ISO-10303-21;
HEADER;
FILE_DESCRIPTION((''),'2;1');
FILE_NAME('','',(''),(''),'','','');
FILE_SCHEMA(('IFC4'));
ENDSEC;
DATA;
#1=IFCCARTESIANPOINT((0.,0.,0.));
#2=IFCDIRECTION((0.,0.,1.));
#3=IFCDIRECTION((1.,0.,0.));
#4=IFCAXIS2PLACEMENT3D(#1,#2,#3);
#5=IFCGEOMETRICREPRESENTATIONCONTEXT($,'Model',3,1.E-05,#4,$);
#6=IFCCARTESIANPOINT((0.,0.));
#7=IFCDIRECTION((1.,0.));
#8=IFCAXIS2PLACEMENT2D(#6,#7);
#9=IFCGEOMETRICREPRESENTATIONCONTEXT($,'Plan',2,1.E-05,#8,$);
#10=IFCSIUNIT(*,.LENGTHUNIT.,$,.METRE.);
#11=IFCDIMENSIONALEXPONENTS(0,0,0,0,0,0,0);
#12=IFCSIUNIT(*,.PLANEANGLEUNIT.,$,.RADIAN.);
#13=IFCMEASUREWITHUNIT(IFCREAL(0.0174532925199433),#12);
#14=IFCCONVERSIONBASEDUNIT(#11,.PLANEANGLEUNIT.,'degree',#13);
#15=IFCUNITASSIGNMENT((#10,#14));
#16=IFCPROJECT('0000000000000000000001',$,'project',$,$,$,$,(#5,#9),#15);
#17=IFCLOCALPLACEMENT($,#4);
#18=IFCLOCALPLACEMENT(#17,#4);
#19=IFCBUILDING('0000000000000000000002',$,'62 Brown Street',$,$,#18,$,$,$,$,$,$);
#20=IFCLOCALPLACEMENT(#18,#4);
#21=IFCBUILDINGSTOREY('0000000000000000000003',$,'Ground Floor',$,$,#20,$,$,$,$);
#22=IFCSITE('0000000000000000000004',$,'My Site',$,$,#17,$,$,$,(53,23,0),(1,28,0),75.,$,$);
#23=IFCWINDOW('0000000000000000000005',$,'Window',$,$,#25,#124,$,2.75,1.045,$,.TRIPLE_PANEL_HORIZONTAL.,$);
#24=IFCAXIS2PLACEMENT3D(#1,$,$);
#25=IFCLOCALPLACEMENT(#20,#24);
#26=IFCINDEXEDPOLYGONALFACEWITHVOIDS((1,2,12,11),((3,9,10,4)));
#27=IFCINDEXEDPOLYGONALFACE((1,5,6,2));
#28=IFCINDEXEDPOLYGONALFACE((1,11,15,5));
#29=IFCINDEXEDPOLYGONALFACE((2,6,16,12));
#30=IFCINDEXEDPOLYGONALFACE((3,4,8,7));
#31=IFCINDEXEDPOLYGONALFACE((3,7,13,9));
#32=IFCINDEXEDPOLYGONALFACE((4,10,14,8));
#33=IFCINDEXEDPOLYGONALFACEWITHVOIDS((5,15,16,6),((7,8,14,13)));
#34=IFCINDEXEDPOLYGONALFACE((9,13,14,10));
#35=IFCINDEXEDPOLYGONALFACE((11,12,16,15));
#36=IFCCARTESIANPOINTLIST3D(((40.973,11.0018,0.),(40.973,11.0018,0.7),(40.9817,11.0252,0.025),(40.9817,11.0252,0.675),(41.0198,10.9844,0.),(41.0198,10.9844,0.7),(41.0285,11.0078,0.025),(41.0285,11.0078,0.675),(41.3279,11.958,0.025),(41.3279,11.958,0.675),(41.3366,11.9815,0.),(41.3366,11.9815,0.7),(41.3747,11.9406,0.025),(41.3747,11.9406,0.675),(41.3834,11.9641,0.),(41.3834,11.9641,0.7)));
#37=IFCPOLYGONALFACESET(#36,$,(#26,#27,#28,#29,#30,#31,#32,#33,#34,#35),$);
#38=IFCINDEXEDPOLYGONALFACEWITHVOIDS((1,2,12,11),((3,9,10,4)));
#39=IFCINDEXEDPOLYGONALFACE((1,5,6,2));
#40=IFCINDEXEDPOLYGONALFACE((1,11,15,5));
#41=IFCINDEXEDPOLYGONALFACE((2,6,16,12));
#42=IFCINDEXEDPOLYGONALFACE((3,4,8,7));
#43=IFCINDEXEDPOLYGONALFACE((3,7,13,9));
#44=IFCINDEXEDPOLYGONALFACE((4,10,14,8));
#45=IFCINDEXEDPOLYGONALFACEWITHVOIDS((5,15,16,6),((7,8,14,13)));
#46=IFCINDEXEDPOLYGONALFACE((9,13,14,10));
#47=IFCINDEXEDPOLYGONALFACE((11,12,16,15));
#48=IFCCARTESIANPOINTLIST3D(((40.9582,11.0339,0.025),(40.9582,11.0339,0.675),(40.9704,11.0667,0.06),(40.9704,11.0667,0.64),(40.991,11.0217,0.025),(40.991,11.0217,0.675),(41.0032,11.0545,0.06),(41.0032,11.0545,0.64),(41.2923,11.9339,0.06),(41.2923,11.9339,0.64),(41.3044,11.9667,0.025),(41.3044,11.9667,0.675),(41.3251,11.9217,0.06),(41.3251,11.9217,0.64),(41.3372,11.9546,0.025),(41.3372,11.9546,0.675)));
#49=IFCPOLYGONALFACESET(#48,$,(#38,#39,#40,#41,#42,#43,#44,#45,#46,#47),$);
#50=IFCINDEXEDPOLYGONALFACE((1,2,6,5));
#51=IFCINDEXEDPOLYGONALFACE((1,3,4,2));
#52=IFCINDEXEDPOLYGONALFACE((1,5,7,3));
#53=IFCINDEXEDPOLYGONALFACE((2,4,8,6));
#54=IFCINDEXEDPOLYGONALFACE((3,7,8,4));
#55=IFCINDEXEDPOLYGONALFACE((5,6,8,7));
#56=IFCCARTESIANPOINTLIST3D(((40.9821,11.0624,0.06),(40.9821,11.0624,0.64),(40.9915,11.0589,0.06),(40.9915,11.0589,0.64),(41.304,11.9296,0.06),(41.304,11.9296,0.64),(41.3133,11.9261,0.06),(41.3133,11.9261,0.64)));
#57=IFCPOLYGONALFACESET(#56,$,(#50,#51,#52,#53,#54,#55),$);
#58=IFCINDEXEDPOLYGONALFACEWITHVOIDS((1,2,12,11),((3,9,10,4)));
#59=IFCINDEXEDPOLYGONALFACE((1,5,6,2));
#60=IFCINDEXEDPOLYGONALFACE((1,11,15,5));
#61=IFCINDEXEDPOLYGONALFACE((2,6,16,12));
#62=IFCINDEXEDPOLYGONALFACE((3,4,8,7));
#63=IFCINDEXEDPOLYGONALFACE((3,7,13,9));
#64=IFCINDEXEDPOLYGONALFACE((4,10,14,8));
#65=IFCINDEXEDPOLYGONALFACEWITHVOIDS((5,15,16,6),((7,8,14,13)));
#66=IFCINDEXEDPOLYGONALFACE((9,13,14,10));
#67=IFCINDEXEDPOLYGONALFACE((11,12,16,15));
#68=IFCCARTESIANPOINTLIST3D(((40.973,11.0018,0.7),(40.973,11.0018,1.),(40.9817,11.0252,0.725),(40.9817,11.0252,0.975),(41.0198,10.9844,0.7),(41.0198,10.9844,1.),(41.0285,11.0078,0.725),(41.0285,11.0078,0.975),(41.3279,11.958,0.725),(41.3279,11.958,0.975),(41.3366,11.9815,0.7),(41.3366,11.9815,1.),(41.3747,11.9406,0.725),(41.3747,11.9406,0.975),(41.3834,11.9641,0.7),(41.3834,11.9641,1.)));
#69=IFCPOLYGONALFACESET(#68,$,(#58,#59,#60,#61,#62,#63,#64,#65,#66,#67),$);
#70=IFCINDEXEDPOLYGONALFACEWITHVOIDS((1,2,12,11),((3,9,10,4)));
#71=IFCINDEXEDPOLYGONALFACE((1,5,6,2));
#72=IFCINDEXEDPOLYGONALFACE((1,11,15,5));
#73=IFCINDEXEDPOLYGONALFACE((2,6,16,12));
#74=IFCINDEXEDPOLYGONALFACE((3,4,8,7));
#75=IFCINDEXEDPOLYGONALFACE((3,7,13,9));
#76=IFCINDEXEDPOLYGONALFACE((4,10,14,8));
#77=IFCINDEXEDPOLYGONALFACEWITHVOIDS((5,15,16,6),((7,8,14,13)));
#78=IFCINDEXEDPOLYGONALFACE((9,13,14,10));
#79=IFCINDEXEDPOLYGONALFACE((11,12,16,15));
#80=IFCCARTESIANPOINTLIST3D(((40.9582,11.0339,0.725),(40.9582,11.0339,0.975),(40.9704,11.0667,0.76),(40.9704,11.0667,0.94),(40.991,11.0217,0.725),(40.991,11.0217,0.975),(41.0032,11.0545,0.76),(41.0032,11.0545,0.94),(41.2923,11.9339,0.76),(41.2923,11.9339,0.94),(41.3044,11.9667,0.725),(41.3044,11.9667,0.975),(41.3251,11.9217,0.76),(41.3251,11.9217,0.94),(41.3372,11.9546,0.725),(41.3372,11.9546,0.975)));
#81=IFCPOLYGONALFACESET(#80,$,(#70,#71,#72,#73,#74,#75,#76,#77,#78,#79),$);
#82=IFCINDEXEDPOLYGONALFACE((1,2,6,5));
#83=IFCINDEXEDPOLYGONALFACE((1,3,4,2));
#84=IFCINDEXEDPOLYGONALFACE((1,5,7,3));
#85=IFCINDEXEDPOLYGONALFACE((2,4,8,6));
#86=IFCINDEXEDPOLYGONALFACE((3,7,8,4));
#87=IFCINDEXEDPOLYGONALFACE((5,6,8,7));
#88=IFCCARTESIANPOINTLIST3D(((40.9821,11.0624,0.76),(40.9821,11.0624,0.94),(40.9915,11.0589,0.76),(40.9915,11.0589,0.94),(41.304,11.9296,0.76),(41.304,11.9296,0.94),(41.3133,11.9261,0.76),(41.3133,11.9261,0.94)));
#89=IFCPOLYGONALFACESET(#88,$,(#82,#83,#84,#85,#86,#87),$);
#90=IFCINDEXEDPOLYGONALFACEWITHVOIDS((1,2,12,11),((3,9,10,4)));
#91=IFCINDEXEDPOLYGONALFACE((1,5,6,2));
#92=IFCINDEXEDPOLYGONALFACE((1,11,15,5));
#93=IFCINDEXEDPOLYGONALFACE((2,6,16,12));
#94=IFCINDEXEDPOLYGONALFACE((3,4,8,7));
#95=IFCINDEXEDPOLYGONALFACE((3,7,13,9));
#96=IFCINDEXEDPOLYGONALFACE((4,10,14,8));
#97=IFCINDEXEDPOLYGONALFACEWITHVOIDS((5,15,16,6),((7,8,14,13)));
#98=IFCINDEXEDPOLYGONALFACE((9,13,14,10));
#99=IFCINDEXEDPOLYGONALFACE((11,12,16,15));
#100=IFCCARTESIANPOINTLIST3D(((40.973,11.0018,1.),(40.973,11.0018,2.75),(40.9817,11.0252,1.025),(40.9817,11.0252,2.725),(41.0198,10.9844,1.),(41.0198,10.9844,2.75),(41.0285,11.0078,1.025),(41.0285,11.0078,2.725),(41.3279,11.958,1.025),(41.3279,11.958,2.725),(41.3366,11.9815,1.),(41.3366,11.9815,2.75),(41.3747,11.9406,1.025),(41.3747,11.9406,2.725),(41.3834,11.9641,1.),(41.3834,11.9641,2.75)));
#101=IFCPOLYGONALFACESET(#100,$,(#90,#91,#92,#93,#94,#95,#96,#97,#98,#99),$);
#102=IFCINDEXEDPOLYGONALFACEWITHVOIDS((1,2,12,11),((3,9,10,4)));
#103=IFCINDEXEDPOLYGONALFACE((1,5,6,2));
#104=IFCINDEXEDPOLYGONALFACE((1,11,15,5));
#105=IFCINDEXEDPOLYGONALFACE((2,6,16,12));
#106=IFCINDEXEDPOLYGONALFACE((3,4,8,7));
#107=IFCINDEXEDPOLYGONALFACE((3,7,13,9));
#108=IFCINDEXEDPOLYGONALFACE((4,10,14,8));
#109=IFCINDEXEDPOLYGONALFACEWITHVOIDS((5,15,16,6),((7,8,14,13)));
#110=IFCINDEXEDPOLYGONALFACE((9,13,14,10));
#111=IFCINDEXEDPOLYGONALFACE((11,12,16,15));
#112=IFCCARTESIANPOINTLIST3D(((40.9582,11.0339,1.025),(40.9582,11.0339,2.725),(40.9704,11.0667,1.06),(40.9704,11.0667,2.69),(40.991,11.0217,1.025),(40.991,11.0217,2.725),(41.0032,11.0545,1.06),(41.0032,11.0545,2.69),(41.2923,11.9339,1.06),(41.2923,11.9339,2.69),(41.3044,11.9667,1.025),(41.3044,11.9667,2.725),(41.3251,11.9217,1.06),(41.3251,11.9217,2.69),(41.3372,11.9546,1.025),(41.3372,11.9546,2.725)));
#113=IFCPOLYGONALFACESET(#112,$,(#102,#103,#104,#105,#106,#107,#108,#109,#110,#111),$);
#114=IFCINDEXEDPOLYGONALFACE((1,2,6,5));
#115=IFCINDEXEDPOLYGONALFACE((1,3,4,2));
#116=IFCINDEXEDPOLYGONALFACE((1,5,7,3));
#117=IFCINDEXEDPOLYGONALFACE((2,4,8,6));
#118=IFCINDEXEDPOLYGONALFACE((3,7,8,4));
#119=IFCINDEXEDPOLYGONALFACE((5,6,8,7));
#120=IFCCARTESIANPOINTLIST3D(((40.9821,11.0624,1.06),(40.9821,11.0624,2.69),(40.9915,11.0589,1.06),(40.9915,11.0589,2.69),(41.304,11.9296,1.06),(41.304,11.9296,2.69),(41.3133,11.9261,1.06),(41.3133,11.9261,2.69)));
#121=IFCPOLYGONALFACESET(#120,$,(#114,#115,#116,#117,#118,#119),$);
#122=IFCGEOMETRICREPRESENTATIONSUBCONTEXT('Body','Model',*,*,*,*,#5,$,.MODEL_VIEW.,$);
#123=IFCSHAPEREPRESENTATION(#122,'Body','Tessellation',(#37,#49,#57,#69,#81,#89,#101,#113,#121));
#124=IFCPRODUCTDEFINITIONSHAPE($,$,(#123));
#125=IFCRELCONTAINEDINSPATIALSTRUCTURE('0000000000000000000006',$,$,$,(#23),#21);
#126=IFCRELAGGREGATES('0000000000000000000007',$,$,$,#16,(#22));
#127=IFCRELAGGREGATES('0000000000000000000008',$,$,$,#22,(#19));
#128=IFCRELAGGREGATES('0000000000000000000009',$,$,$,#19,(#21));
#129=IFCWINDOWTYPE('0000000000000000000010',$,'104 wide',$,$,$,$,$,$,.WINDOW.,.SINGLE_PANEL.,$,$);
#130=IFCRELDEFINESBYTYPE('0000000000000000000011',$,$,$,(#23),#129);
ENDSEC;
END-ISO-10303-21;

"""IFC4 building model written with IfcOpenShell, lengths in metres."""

from ifc_helpers import new_model, entity, si_unit, converted_unit, frame, origin_with_axes, origin_2d_with_axis, place, context, subcontext, project, spatial, line, indexed_curve, outline, extrude, shape, source, transform, mapped, type_object, type_shapes, element, save


model = new_model("IFC4")

# Units and contexts
model_context = context("Model", 3, precision=1e-05, world=origin_with_axes())
plan_context = context("Plan", 2, precision=1e-05, world=origin_2d_with_axis())
body_context_1 = subcontext(model_context, "Body", "Model", "MODEL_VIEW")
body_context_2 = subcontext(plan_context, "Body", "Plan", "PLAN_VIEW")
ifc_project = project(units=[si_unit("LENGTHUNIT", "METRE"), converted_unit("PLANEANGLEUNIT", "degree", entity("IfcReal", 0.0174532925199433), si_unit("PLANEANGLEUNIT", "RADIAN"), dimensions=[0, 0, 0, 0, 0, 0, 0])], contexts=[model_context, plan_context])

# Site, building, storey
site_placement = place(None, origin_with_axes())
site = spatial("IfcSite", under=ifc_project, at=site_placement, Name="My Site", RefLatitude=(53, 23, 0), RefLongitude=(1, 28, 0), RefElevation=75.0)
building_placement = place(site_placement, origin_with_axes())
building = spatial("IfcBuilding", under=site, at=building_placement, Name="62 Brown Street")
storey_placement = place(building_placement, origin_with_axes())
storey = spatial("IfcBuildingStorey", under=building, at=storey_placement, Name="Ground Floor")

# Window
window_type_1 = type_object("IfcWindowType", Name="104 wide", PartitioningType="SINGLE_PANEL", PredefinedType="WINDOW")
shared_shape_1 = source(origin_with_axes(), body_context_1, "Body", "SweptSolid", [
    extrude(outline(indexed_curve([(0.0, 0.0), (1.045, 0.0), (1.045, 0.7), (0.0, 0.7)], segments=[line(1, 2, 3, 4, 1)]), holes=[indexed_curve([(0.025, 0.025), (1.02, 0.025), (1.02, 0.675), (0.025, 0.675)], segments=[line(1, 2, 3, 4, 1)])]), frame((0.0, 0.15, 0.0), z_axis=(0.0, -1.0, 0.0), x_axis=(1.0, 0.0, 0.0)), (0.0, 0.0, -1.0), 0.05),
    extrude(outline(indexed_curve([(0.0, 0.0), (0.995, 0.0), (0.995, 0.65), (0.0, 0.65)], segments=[line(1, 2, 3, 4, 1)]), holes=[indexed_curve([(0.035, 0.035), (0.96, 0.035), (0.96, 0.615), (0.035, 0.615)], segments=[line(1, 2, 3, 4, 1)])]), frame((0.025, 0.19, 0.025), z_axis=(0.0, -1.0, 0.0), x_axis=(1.0, 0.0, 0.0)), (0.0, 0.0, -1.0), 0.035),
    extrude(outline(indexed_curve([(0.035, 0.035), (0.96, 0.035), (0.96, 0.615), (0.035, 0.615)], segments=[line(1, 2, 3, 4, 1)])), frame((0.025, 0.2025, 0.025), z_axis=(0.0, -1.0, 0.0), x_axis=(1.0, 0.0, 0.0)), (0.0, 0.0, -1.0), 0.01),
    extrude(outline(indexed_curve([(0.0, 0.0), (1.045, 0.0), (1.045, 0.3), (0.0, 0.3)], segments=[line(1, 2, 3, 4, 1)]), holes=[indexed_curve([(0.025, 0.025), (1.02, 0.025), (1.02, 0.275), (0.025, 0.275)], segments=[line(1, 2, 3, 4, 1)])]), frame((0.0, 0.15, 0.7), z_axis=(0.0, -1.0, 0.0), x_axis=(1.0, 0.0, 0.0)), (0.0, 0.0, -1.0), 0.05),
    extrude(outline(indexed_curve([(0.0, 0.0), (0.995, 0.0), (0.995, 0.25), (0.0, 0.25)], segments=[line(1, 2, 3, 4, 1)]), holes=[indexed_curve([(0.035, 0.035), (0.96, 0.035), (0.96, 0.215), (0.035, 0.215)], segments=[line(1, 2, 3, 4, 1)])]), frame((0.025, 0.19, 0.725), z_axis=(0.0, -1.0, 0.0), x_axis=(1.0, 0.0, 0.0)), (0.0, 0.0, -1.0), 0.035),
    extrude(outline(indexed_curve([(0.035, 0.035), (0.96, 0.035), (0.96, 0.215), (0.035, 0.215)], segments=[line(1, 2, 3, 4, 1)])), frame((0.025, 0.2025, 0.725), z_axis=(0.0, -1.0, 0.0), x_axis=(1.0, 0.0, 0.0)), (0.0, 0.0, -1.0), 0.01),
    extrude(outline(indexed_curve([(0.0, 0.0), (1.045, 0.0), (1.045, 1.75), (0.0, 1.75)], segments=[line(1, 2, 3, 4, 1)]), holes=[indexed_curve([(0.025, 0.025), (1.02, 0.025), (1.02, 1.725), (0.025, 1.725)], segments=[line(1, 2, 3, 4, 1)])]), frame((0.0, 0.15, 1.0), z_axis=(0.0, -1.0, 0.0), x_axis=(1.0, 0.0, 0.0)), (0.0, 0.0, -1.0), 0.05),
    extrude(outline(indexed_curve([(0.0, 0.0), (0.995, 0.0), (0.995, 1.7), (0.0, 1.7)], segments=[line(1, 2, 3, 4, 1)]), holes=[indexed_curve([(0.035, 0.035), (0.96, 0.035), (0.96, 1.665), (0.035, 1.665)], segments=[line(1, 2, 3, 4, 1)])]), frame((0.025, 0.19, 1.025), z_axis=(0.0, -1.0, 0.0), x_axis=(1.0, 0.0, 0.0)), (0.0, 0.0, -1.0), 0.035),
    extrude(outline(indexed_curve([(0.035, 0.035), (0.96, 0.035), (0.96, 1.665), (0.035, 1.665)], segments=[line(1, 2, 3, 4, 1)])), frame((0.025, 0.2025, 1.025), z_axis=(0.0, -1.0, 0.0), x_axis=(1.0, 0.0, 0.0)), (0.0, 0.0, -1.0), 0.01),
])
shared_shape_2 = source(origin_with_axes(), body_context_2, "Body", "Curve2D", [
    entity("IfcIndexedPolyCurve", entity("IfcCartesianPointList2D", [[0.025, 0.15], [1.02, 0.15]])),
    entity("IfcIndexedPolyCurve", entity("IfcCartesianPointList2D", [[0.0, 0.2], [0.025, 0.2], [0.025, 0.15], [0.0, 0.15]]), [entity("IfcLineIndex", [1, 2, 3, 4, 1])]),
    entity("IfcIndexedPolyCurve", entity("IfcCartesianPointList2D", [[1.045, 0.2], [1.02, 0.2], [1.02, 0.15], [1.045, 0.15]]), [entity("IfcLineIndex", [1, 2, 3, 4, 1])]),
    entity("IfcIndexedPolyCurve", entity("IfcCartesianPointList2D", [[0.025, 0.19], [0.06, 0.19], [0.06, 0.225], [0.025, 0.225]]), [entity("IfcLineIndex", [1, 2, 3, 4, 1])]),
    entity("IfcIndexedPolyCurve", entity("IfcCartesianPointList2D", [[1.02, 0.19], [0.985, 0.19], [0.985, 0.225], [1.02, 0.225]]), [entity("IfcLineIndex", [1, 2, 3, 4, 1])]),
    entity("IfcIndexedPolyCurve", entity("IfcCartesianPointList2D", [[0.06, 0.19], [0.985, 0.19]])),
    entity("IfcIndexedPolyCurve", entity("IfcCartesianPointList2D", [[0.06, 0.225], [0.985, 0.225]])),
    entity("IfcIndexedPolyCurve", entity("IfcCartesianPointList2D", [[0.06, 0.2075], [0.985, 0.2075]])),
])
type_shapes(window_type_1, [shared_shape_1, shared_shape_2])
placement_1 = place(storey_placement, frame((39.024, 5.1755, 0.0), z_axis=(0.0, 0.0, 1.0), x_axis=(0.347944, 0.937515, 0.0)))
placement_2 = place(placement_1, frame((6.1404, 0.0, 0.0), z_axis=(0.0, 0.0, 1.0), x_axis=(1.0, 0.0, 0.0)))
window_1_placement = place(placement_2, frame((0.0, 0.0, 0.0), z_axis=(0.0, 0.0, 1.0), x_axis=(1.0, 0.0, 0.0)))
element("IfcWindow", 1, at=window_1_placement, inside=storey, type_object=window_type_1, Name="Window", OverallHeight=2.75, OverallWidth=1.045, PartitioningType="TRIPLE_PANEL_HORIZONTAL", shapes=[
    shape(body_context_1, "Body", "MappedRepresentation", [mapped(shared_shape_1, transform((0.0, 0.0, 0.0), x_axis=(1.0, 0.0, 0.0), y_axis=(0.0, 1.0, 0.0), z_axis=(0.0, 0.0, 1.0), scale=1.0))]),
    shape(body_context_2, "Body", "MappedRepresentation", [mapped(shared_shape_2, transform((0.0, 0.0, 0.0), x_axis=(1.0, 0.0, 0.0), y_axis=(0.0, 1.0, 0.0), z_axis=(0.0, 0.0, 1.0), scale=1.0))]),
])

save(model, "model.ifc")
